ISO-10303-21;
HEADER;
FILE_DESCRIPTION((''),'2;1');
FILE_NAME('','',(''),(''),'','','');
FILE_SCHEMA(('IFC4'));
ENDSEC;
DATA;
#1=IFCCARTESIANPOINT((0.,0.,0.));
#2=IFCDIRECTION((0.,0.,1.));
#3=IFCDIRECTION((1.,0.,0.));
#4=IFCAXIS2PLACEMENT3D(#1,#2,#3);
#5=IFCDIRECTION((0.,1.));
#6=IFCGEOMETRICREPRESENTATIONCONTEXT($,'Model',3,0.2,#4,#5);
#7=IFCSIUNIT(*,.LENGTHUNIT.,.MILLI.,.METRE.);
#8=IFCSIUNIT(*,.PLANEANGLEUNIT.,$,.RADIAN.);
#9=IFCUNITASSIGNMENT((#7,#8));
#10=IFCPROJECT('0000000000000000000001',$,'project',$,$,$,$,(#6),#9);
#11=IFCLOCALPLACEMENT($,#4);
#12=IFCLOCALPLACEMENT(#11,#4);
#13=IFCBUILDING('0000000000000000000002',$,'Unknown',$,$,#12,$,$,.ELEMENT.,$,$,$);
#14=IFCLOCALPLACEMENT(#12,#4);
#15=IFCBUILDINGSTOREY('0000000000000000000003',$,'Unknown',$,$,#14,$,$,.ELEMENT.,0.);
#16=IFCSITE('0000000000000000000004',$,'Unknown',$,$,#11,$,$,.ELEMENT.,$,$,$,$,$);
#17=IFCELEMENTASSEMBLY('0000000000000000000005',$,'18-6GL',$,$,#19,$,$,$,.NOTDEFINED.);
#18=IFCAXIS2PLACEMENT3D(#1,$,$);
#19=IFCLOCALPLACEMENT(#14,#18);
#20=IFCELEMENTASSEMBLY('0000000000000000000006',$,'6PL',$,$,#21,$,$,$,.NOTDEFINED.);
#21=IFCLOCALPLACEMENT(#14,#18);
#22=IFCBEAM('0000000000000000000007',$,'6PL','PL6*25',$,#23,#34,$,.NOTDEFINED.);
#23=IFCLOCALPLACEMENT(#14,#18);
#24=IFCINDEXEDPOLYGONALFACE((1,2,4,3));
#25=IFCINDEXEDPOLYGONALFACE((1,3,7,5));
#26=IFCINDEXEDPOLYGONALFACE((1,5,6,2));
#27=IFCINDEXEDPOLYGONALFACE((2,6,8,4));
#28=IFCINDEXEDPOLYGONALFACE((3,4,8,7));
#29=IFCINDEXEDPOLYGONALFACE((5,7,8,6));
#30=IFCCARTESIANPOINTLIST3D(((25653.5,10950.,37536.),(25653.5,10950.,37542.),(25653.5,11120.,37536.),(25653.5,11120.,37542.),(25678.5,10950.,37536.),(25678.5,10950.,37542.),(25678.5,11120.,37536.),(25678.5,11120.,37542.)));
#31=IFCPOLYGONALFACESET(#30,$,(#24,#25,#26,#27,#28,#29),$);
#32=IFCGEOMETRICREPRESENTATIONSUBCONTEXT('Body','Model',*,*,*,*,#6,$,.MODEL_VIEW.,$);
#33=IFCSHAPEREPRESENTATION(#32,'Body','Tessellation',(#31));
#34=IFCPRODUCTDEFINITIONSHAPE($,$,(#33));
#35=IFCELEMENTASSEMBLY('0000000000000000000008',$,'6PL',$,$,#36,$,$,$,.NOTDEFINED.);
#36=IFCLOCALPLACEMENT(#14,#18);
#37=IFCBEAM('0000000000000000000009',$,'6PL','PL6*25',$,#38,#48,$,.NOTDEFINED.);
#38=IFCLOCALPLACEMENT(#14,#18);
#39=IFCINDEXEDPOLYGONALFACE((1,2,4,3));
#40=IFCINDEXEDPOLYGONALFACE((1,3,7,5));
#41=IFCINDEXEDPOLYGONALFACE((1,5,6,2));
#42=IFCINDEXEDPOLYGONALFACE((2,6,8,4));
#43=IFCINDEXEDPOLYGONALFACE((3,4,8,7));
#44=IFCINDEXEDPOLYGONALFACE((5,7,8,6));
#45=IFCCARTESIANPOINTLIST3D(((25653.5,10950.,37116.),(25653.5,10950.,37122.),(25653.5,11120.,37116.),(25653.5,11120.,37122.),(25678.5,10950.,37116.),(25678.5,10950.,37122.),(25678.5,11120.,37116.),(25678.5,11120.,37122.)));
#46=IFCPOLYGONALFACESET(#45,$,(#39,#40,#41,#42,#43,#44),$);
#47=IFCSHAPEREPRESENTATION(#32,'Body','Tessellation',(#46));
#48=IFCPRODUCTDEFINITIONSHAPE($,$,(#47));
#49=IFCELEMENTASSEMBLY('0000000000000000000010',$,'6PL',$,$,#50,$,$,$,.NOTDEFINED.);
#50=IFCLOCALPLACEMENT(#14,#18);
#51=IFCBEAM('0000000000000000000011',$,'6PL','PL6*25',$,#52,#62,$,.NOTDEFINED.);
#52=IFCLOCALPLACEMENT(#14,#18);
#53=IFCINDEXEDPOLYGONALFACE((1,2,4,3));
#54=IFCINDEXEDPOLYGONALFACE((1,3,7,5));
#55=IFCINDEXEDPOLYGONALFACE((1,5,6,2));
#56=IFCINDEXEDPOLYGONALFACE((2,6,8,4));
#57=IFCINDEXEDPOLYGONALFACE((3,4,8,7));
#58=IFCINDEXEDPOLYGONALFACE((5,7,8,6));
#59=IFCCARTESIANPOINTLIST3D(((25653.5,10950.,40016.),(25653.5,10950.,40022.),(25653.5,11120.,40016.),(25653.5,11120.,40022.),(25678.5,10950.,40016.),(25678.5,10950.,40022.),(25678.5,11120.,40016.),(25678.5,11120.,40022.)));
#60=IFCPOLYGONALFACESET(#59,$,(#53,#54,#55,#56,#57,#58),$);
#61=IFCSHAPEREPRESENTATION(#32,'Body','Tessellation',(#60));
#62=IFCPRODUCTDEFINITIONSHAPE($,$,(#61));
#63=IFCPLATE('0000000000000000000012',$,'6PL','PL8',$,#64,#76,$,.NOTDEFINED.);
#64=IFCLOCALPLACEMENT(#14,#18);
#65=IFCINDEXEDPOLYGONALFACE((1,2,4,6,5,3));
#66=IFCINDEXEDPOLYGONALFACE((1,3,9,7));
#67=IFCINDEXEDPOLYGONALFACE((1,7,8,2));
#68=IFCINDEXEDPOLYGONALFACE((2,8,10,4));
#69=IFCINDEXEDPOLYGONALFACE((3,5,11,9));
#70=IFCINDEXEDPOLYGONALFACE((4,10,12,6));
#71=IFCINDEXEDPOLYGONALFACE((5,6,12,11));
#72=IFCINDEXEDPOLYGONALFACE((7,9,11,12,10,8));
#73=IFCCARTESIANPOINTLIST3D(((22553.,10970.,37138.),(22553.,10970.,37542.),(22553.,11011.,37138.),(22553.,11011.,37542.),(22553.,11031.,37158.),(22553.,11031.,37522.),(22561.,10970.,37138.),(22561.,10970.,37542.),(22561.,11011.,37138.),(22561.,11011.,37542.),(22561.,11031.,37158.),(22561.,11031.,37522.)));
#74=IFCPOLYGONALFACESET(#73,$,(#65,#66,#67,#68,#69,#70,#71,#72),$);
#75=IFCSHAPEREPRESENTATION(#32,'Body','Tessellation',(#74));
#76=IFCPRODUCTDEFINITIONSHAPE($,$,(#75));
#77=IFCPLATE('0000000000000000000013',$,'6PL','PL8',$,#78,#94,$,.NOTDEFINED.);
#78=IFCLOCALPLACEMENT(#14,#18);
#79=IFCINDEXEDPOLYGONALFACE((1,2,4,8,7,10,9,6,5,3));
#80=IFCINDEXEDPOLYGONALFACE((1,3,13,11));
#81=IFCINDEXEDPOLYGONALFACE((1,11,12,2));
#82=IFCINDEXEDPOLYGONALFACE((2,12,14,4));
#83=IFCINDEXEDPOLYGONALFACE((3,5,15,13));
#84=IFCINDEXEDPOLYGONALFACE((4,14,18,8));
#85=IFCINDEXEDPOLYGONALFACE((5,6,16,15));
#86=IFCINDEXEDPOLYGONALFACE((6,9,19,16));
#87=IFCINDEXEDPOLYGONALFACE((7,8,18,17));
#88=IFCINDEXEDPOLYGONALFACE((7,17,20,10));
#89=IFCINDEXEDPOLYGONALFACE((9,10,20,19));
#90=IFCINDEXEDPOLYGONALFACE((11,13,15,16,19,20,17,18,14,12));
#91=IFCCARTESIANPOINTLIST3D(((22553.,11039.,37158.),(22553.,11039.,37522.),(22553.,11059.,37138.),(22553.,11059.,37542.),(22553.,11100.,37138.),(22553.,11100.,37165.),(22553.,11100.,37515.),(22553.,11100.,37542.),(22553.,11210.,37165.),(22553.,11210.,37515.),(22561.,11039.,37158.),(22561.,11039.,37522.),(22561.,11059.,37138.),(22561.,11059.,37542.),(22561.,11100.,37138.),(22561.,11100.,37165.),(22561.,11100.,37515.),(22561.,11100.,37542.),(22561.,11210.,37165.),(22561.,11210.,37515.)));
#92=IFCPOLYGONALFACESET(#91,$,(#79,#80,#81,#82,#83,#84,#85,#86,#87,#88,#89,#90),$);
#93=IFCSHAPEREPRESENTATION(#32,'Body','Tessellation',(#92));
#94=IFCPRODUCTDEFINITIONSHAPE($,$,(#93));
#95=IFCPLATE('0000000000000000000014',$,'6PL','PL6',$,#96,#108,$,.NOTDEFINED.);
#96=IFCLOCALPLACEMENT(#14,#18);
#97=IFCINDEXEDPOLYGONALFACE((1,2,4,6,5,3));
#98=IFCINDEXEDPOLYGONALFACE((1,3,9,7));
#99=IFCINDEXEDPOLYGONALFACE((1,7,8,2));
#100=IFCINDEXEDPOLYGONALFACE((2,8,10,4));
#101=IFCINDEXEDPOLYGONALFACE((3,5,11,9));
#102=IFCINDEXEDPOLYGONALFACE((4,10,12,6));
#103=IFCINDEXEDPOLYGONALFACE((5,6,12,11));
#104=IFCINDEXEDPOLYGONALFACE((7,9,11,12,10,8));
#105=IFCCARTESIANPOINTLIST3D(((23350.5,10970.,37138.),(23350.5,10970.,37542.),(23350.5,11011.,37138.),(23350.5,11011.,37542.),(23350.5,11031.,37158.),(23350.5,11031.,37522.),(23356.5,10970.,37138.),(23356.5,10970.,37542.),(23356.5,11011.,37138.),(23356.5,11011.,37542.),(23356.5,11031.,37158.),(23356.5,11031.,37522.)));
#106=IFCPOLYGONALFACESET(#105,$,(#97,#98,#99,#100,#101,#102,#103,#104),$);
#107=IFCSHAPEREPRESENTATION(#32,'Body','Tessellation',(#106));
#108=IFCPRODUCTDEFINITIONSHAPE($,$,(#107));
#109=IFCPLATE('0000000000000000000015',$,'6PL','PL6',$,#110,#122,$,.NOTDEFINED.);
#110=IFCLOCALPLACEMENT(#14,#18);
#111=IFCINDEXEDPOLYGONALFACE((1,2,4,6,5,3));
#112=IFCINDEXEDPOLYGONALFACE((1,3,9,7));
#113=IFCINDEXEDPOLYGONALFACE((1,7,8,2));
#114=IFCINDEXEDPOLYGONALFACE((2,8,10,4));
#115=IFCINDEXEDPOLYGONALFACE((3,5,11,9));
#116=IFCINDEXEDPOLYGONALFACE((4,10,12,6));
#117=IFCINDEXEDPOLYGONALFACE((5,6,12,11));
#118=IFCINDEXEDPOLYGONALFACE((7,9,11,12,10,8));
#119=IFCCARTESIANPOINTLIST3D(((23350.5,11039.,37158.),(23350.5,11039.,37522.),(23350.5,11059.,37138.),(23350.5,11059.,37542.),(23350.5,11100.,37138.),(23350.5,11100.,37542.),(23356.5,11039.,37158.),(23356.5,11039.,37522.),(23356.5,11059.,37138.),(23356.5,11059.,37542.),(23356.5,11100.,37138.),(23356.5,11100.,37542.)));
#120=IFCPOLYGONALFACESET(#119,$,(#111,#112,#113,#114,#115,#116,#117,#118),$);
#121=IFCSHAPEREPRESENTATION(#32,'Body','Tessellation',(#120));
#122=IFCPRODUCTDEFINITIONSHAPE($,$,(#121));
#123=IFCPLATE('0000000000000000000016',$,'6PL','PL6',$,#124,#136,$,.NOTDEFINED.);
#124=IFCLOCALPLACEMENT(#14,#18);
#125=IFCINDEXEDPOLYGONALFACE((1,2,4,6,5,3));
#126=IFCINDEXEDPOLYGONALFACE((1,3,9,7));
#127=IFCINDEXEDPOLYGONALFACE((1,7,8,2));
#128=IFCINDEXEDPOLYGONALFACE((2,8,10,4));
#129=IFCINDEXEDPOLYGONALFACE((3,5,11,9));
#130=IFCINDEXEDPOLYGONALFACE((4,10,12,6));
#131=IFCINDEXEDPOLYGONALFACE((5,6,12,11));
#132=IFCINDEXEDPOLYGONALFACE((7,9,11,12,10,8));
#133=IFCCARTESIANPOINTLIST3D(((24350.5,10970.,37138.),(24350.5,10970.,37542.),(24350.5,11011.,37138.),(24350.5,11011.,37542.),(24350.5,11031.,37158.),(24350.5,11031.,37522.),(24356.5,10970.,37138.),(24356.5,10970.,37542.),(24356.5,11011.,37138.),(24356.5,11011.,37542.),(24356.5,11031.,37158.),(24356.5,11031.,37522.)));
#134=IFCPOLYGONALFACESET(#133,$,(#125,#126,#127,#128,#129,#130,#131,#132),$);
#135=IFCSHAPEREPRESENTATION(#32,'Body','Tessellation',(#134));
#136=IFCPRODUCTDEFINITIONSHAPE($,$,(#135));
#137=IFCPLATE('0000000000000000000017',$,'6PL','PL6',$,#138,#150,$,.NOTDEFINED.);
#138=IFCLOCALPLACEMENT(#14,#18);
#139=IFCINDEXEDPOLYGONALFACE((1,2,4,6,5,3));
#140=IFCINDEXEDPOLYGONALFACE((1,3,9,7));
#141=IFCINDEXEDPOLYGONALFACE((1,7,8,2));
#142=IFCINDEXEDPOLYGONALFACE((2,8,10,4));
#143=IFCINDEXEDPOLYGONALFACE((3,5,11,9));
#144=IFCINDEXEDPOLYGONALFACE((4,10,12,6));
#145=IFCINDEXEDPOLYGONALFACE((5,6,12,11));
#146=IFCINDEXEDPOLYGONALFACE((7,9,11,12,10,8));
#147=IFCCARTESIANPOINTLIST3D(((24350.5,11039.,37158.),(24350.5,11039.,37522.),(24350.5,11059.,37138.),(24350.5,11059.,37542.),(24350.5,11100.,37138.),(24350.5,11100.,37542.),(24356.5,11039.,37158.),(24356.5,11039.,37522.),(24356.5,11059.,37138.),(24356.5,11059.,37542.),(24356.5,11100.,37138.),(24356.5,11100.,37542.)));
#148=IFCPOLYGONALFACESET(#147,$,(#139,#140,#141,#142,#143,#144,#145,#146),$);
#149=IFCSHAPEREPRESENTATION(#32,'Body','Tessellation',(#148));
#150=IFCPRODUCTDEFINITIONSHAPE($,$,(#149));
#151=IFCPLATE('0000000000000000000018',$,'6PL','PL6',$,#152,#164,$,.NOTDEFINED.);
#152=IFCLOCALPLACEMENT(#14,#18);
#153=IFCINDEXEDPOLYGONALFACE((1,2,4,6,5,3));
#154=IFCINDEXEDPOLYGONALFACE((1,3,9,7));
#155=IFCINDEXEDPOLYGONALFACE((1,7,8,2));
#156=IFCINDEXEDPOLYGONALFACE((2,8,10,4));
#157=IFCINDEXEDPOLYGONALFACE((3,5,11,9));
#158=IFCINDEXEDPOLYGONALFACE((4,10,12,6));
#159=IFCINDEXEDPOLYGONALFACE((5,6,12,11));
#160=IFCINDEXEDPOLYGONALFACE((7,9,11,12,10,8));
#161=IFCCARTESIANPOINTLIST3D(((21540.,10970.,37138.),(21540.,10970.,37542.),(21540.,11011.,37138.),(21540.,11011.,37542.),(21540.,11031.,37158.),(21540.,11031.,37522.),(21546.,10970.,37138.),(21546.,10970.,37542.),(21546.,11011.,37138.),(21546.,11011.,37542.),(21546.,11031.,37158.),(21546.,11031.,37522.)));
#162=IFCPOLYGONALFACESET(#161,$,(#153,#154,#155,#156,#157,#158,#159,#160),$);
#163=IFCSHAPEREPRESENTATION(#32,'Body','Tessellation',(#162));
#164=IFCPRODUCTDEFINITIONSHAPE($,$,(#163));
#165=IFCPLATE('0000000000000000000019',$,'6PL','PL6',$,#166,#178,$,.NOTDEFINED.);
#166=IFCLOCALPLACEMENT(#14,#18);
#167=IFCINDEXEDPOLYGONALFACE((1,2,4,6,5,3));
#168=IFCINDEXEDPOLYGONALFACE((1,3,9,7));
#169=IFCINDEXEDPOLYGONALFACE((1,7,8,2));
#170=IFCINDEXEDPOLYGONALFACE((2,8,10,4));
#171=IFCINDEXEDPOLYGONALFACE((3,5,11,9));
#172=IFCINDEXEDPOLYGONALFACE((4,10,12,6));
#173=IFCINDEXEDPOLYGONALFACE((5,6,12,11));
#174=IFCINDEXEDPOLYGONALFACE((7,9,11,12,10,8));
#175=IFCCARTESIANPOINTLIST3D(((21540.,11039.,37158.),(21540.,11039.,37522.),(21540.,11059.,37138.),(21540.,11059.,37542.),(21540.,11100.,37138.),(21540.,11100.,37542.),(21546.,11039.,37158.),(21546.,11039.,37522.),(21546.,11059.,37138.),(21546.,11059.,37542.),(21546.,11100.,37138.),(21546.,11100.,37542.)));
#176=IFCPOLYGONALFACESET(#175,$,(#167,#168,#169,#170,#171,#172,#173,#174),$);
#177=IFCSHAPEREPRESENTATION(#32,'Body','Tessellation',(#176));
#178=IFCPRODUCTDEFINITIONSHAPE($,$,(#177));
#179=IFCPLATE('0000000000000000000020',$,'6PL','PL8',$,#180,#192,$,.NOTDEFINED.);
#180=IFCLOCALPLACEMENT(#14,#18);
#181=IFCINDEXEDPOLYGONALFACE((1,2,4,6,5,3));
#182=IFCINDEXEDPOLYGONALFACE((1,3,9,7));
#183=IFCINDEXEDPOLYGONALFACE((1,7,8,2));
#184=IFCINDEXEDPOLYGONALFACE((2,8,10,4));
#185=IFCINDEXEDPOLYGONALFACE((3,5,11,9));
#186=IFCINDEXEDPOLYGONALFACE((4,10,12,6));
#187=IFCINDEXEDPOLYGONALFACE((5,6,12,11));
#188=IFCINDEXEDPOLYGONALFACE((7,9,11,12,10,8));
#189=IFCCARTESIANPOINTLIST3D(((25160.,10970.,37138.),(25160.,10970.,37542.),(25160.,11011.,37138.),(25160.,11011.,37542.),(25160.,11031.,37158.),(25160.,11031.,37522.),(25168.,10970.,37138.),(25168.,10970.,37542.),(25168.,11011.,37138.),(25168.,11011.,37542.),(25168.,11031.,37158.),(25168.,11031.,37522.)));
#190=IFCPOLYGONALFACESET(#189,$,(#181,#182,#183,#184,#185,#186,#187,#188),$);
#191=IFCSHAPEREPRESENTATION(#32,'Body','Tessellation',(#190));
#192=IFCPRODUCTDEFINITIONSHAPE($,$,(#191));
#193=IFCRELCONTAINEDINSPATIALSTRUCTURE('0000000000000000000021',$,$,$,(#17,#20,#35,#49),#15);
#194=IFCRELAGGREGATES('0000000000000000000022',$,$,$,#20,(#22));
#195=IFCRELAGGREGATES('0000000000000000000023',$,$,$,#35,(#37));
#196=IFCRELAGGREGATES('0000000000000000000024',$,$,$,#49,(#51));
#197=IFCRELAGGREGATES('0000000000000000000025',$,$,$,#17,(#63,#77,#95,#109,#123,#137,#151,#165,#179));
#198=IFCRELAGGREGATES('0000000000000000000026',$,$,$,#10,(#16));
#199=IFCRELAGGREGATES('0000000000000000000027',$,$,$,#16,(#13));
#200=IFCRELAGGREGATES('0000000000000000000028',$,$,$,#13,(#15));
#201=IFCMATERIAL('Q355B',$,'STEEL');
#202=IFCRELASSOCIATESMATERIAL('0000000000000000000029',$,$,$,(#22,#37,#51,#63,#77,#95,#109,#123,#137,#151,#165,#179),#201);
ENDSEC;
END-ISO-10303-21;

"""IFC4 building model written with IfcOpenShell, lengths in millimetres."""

from ifc_helpers import new_model, si_unit, direction, frame, origin_with_axes, place, context, subcontext, project, spatial, line, indexed_curve, outline, extrude, material, element, aggregate, save


model = new_model("IFC4")

# Units and contexts
model_context = context("Model", 3, precision=0.2, world=origin_with_axes(), true_north=direction((0.0, 1.0)))
body_context = subcontext(model_context, "Body", "Model", "MODEL_VIEW")
ifc_project = project(units=[si_unit("LENGTHUNIT", "METRE", prefix="MILLI"), si_unit("PLANEANGLEUNIT", "RADIAN")], contexts=[model_context])

# Site, building, storey
site_placement = place(None, origin_with_axes())
site = spatial("IfcSite", under=ifc_project, at=site_placement, Name="Unknown", CompositionType="ELEMENT")
building_placement = place(site_placement, origin_with_axes())
building = spatial("IfcBuilding", under=site, at=building_placement, Name="Unknown", CompositionType="ELEMENT")
storey_placement = place(building_placement, origin_with_axes())
storey = spatial("IfcBuildingStorey", under=building, at=storey_placement, Name="Unknown", CompositionType="ELEMENT", Elevation=0.0)

# Element assemblies, beams
assembly_1_placement = place(storey_placement, frame((21150.0, 11035.0, 37340.0), z_axis=(0.0, -1.0, 0.0), x_axis=(1.0, 0.0, 0.0)))
assembly_1 = element("IfcElementAssembly", 1, at=assembly_1_placement, inside=storey, Name="18-6GL", PredefinedType="NOTDEFINED")
assembly_2_placement = place(storey_placement, frame((25666.0, 11120.0, 37539.0), z_axis=(0.0, 0.0, -1.0), x_axis=(0.0, -1.0, 0.0)))
assembly_2 = element("IfcElementAssembly", 2, at=assembly_2_placement, inside=storey, Name="6PL", PredefinedType="NOTDEFINED")
ifc_material_1 = material(Name="Q355B", Category="STEEL")
beam_1_placement = place(assembly_2_placement, origin_with_axes())
beam_1 = element("IfcBeam", 3, at=beam_1_placement, material=ifc_material_1, Name="6PL", Description="PL6*25", PredefinedType="NOTDEFINED", context=body_context, shape_type="SolidModel", body=[
    extrude(outline(indexed_curve([(-3.0, -12.5), (3.0, -12.5), (3.0, 12.5), (-3.0, 12.5)], segments=[line(1, 2, 3, 4, 1)])), frame((0.0, 0.0, 0.0), z_axis=(-1.0, 0.0, 0.0), x_axis=(0.0, 0.0, 1.0)), (0.0, 0.0, -1.0), 170.0),
])
aggregate(assembly_2, [beam_1])
assembly_3_placement = place(storey_placement, frame((25666.0, 11120.0, 37119.0), z_axis=(0.0, 0.0, -1.0), x_axis=(0.0, -1.0, 0.0)))
assembly_3 = element("IfcElementAssembly", 4, at=assembly_3_placement, inside=storey, Name="6PL", PredefinedType="NOTDEFINED")
beam_2_placement = place(assembly_3_placement, origin_with_axes())
beam_2 = element("IfcBeam", 5, at=beam_2_placement, material=ifc_material_1, Name="6PL", Description="PL6*25", PredefinedType="NOTDEFINED", context=body_context, shape_type="SolidModel", body=[
    extrude(outline(indexed_curve([(-3.0, -12.5), (3.0, -12.5), (3.0, 12.5), (-3.0, 12.5)], segments=[line(1, 2, 3, 4, 1)])), frame((0.0, 0.0, 0.0), z_axis=(-1.0, 0.0, 0.0), x_axis=(0.0, 0.0, 1.0)), (0.0, 0.0, -1.0), 170.0),
])
aggregate(assembly_3, [beam_2])
assembly_4_placement = place(storey_placement, frame((25666.0, 11120.0, 40019.0), z_axis=(0.0, 0.0, -1.0), x_axis=(0.0, -1.0, 0.0)))
assembly_4 = element("IfcElementAssembly", 6, at=assembly_4_placement, inside=storey, Name="6PL", PredefinedType="NOTDEFINED")
beam_3_placement = place(assembly_4_placement, origin_with_axes())
beam_3 = element("IfcBeam", 7, at=beam_3_placement, material=ifc_material_1, Name="6PL", Description="PL6*25", PredefinedType="NOTDEFINED", context=body_context, shape_type="SolidModel", body=[
    extrude(outline(indexed_curve([(-3.0, -12.5), (3.0, -12.5), (3.0, 12.5), (-3.0, 12.5)], segments=[line(1, 2, 3, 4, 1)])), frame((0.0, 0.0, 0.0), z_axis=(-1.0, 0.0, 0.0), x_axis=(0.0, 0.0, 1.0)), (0.0, 0.0, -1.0), 170.0),
])
aggregate(assembly_4, [beam_3])

# Plates
plate_1_placement = place(assembly_1_placement, frame((1407.0, -202.0, 4.0), z_axis=(-1.0, 0.0, 0.0), x_axis=(0.0, 0.0, 1.0)))
plate_1 = element("IfcPlate", 8, at=plate_1_placement, material=ifc_material_1, Name="6PL", Description="PL8", PredefinedType="NOTDEFINED", context=body_context, shape_type="SolidModel", body=[
    extrude(outline(indexed_curve([(0.0, 20.0), (20.0, 0.0), (61.0, 0.0), (61.0, 404.0), (20.0, 404.0), (0.0, 384.0)], segments=[line(1, 2, 3, 4, 5, 6, 1)])), frame((0.0, 0.0, 4.0), z_axis=(0.0, 0.0, 1.0), x_axis=(1.0, 0.0, 0.0)), (0.0, 0.0, -1.0), 8.0),
])
plate_2_placement = place(assembly_1_placement, frame((1407.0, -182.0, -4.0), z_axis=(1.0, 0.0, 0.0), x_axis=(0.0, -0.707107, -0.707107)))
plate_2 = element("IfcPlate", 9, at=plate_2_placement, material=ifc_material_1, Name="6PL", Description="PL8", PredefinedType="NOTDEFINED", context=body_context, shape_type="SolidModel", body=[
    extrude(outline(indexed_curve([(0.0, 0.0), (28.3, 0.0), (57.3, 29.0), (38.2, 48.1), (116.0, 125.9), (-131.5, 373.4), (-209.3, 295.6), (-228.4, 314.7), (-257.4, 285.7), (-257.4, 257.4)], segments=[line(1, 2, 3, 4, 5, 6, 7, 8, 9, 10, 1)])), frame((0.0, 0.0, 4.0), z_axis=(0.0, 0.0, 1.0), x_axis=(1.0, 0.0, 0.0)), (0.0, 0.0, -1.0), 8.0),
])
plate_3_placement = place(assembly_1_placement, frame((2203.5, -202.0, 65.0), z_axis=(1.0, 0.0, 0.0), x_axis=(0.0, 0.0, -1.0)))
plate_3 = element("IfcPlate", 10, at=plate_3_placement, material=ifc_material_1, Name="6PL", Description="PL6", PredefinedType="NOTDEFINED", context=body_context, shape_type="SolidModel", body=[
    extrude(outline(indexed_curve([(0.0, 0.0), (41.0, 0.0), (61.0, 20.0), (61.0, 384.0), (41.0, 404.0), (0.0, 404.0)], segments=[line(1, 2, 3, 4, 5, 6, 1)])), frame((0.0, 0.0, 3.0), z_axis=(0.0, 0.0, 1.0), x_axis=(1.0, 0.0, 0.0)), (0.0, 0.0, -1.0), 6.0),
])
plate_4_placement = place(assembly_1_placement, frame((2203.5, -202.0, -4.0), z_axis=(1.0, 0.0, 0.0), x_axis=(0.0, 0.0, -1.0)))
plate_4 = element("IfcPlate", 11, at=plate_4_placement, material=ifc_material_1, Name="6PL", Description="PL6", PredefinedType="NOTDEFINED", context=body_context, shape_type="SolidModel", body=[
    extrude(outline(indexed_curve([(0.0, 20.0), (20.0, 0.0), (61.0, 0.0), (61.0, 404.0), (20.0, 404.0), (0.0, 384.0)], segments=[line(1, 2, 3, 4, 5, 6, 1)])), frame((0.0, 0.0, 3.0), z_axis=(0.0, 0.0, 1.0), x_axis=(1.0, 0.0, 0.0)), (0.0, 0.0, -1.0), 6.0),
])
plate_5_placement = place(assembly_1_placement, frame((3203.5, -202.0, 65.0), z_axis=(1.0, 0.0, 0.0), x_axis=(0.0, 0.0, -1.0)))
plate_5 = element("IfcPlate", 12, at=plate_5_placement, material=ifc_material_1, Name="6PL", Description="PL6", PredefinedType="NOTDEFINED", context=body_context, shape_type="SolidModel", body=[
    extrude(outline(indexed_curve([(0.0, 0.0), (41.0, 0.0), (61.0, 20.0), (61.0, 384.0), (41.0, 404.0), (0.0, 404.0)], segments=[line(1, 2, 3, 4, 5, 6, 1)])), frame((0.0, 0.0, 3.0), z_axis=(0.0, 0.0, 1.0), x_axis=(1.0, 0.0, 0.0)), (0.0, 0.0, -1.0), 6.0),
])
plate_6_placement = place(assembly_1_placement, frame((3203.5, -202.0, -4.0), z_axis=(1.0, 0.0, 0.0), x_axis=(0.0, 0.0, -1.0)))
plate_6 = element("IfcPlate", 13, at=plate_6_placement, material=ifc_material_1, Name="6PL", Description="PL6", PredefinedType="NOTDEFINED", context=body_context, shape_type="SolidModel", body=[
    extrude(outline(indexed_curve([(0.0, 20.0), (20.0, 0.0), (61.0, 0.0), (61.0, 404.0), (20.0, 404.0), (0.0, 384.0)], segments=[line(1, 2, 3, 4, 5, 6, 1)])), frame((0.0, 0.0, 3.0), z_axis=(0.0, 0.0, 1.0), x_axis=(1.0, 0.0, 0.0)), (0.0, 0.0, -1.0), 6.0),
])
plate_7_placement = place(assembly_1_placement, frame((393.0, -202.0, 65.0), z_axis=(1.0, 0.0, 0.0), x_axis=(0.0, 0.0, -1.0)))
plate_7 = element("IfcPlate", 14, at=plate_7_placement, material=ifc_material_1, Name="6PL", Description="PL6", PredefinedType="NOTDEFINED", context=body_context, shape_type="SolidModel", body=[
    extrude(outline(indexed_curve([(0.0, 0.0), (41.0, 0.0), (61.0, 20.0), (61.0, 384.0), (41.0, 404.0), (0.0, 404.0)], segments=[line(1, 2, 3, 4, 5, 6, 1)])), frame((0.0, 0.0, 3.0), z_axis=(0.0, 0.0, 1.0), x_axis=(1.0, 0.0, 0.0)), (0.0, 0.0, -1.0), 6.0),
])
plate_8_placement = place(assembly_1_placement, frame((393.0, -202.0, -4.0), z_axis=(1.0, 0.0, 0.0), x_axis=(0.0, 0.0, -1.0)))
plate_8 = element("IfcPlate", 15, at=plate_8_placement, material=ifc_material_1, Name="6PL", Description="PL6", PredefinedType="NOTDEFINED", context=body_context, shape_type="SolidModel", body=[
    extrude(outline(indexed_curve([(0.0, 20.0), (20.0, 0.0), (61.0, 0.0), (61.0, 404.0), (20.0, 404.0), (0.0, 384.0)], segments=[line(1, 2, 3, 4, 5, 6, 1)])), frame((0.0, 0.0, 3.0), z_axis=(0.0, 0.0, 1.0), x_axis=(1.0, 0.0, 0.0)), (0.0, 0.0, -1.0), 6.0),
])
plate_9_placement = place(assembly_1_placement, frame((4014.0, -202.0, 65.0), z_axis=(1.0, 0.0, 0.0), x_axis=(0.0, 0.0, -1.0)))
plate_9 = element("IfcPlate", 16, at=plate_9_placement, material=ifc_material_1, Name="6PL", Description="PL8", PredefinedType="NOTDEFINED", context=body_context, shape_type="SolidModel", body=[
    extrude(outline(indexed_curve([(0.0, 0.0), (41.0, 0.0), (61.0, 20.0), (61.0, 384.0), (41.0, 404.0), (0.0, 404.0)], segments=[line(1, 2, 3, 4, 5, 6, 1)])), frame((0.0, 0.0, 4.0), z_axis=(0.0, 0.0, 1.0), x_axis=(1.0, 0.0, 0.0)), (0.0, 0.0, -1.0), 8.0),
])
aggregate(assembly_1, [plate_1, plate_2, plate_3, plate_4, plate_5, plate_6, plate_7, plate_8, plate_9])

save(model, "model.ifc")
